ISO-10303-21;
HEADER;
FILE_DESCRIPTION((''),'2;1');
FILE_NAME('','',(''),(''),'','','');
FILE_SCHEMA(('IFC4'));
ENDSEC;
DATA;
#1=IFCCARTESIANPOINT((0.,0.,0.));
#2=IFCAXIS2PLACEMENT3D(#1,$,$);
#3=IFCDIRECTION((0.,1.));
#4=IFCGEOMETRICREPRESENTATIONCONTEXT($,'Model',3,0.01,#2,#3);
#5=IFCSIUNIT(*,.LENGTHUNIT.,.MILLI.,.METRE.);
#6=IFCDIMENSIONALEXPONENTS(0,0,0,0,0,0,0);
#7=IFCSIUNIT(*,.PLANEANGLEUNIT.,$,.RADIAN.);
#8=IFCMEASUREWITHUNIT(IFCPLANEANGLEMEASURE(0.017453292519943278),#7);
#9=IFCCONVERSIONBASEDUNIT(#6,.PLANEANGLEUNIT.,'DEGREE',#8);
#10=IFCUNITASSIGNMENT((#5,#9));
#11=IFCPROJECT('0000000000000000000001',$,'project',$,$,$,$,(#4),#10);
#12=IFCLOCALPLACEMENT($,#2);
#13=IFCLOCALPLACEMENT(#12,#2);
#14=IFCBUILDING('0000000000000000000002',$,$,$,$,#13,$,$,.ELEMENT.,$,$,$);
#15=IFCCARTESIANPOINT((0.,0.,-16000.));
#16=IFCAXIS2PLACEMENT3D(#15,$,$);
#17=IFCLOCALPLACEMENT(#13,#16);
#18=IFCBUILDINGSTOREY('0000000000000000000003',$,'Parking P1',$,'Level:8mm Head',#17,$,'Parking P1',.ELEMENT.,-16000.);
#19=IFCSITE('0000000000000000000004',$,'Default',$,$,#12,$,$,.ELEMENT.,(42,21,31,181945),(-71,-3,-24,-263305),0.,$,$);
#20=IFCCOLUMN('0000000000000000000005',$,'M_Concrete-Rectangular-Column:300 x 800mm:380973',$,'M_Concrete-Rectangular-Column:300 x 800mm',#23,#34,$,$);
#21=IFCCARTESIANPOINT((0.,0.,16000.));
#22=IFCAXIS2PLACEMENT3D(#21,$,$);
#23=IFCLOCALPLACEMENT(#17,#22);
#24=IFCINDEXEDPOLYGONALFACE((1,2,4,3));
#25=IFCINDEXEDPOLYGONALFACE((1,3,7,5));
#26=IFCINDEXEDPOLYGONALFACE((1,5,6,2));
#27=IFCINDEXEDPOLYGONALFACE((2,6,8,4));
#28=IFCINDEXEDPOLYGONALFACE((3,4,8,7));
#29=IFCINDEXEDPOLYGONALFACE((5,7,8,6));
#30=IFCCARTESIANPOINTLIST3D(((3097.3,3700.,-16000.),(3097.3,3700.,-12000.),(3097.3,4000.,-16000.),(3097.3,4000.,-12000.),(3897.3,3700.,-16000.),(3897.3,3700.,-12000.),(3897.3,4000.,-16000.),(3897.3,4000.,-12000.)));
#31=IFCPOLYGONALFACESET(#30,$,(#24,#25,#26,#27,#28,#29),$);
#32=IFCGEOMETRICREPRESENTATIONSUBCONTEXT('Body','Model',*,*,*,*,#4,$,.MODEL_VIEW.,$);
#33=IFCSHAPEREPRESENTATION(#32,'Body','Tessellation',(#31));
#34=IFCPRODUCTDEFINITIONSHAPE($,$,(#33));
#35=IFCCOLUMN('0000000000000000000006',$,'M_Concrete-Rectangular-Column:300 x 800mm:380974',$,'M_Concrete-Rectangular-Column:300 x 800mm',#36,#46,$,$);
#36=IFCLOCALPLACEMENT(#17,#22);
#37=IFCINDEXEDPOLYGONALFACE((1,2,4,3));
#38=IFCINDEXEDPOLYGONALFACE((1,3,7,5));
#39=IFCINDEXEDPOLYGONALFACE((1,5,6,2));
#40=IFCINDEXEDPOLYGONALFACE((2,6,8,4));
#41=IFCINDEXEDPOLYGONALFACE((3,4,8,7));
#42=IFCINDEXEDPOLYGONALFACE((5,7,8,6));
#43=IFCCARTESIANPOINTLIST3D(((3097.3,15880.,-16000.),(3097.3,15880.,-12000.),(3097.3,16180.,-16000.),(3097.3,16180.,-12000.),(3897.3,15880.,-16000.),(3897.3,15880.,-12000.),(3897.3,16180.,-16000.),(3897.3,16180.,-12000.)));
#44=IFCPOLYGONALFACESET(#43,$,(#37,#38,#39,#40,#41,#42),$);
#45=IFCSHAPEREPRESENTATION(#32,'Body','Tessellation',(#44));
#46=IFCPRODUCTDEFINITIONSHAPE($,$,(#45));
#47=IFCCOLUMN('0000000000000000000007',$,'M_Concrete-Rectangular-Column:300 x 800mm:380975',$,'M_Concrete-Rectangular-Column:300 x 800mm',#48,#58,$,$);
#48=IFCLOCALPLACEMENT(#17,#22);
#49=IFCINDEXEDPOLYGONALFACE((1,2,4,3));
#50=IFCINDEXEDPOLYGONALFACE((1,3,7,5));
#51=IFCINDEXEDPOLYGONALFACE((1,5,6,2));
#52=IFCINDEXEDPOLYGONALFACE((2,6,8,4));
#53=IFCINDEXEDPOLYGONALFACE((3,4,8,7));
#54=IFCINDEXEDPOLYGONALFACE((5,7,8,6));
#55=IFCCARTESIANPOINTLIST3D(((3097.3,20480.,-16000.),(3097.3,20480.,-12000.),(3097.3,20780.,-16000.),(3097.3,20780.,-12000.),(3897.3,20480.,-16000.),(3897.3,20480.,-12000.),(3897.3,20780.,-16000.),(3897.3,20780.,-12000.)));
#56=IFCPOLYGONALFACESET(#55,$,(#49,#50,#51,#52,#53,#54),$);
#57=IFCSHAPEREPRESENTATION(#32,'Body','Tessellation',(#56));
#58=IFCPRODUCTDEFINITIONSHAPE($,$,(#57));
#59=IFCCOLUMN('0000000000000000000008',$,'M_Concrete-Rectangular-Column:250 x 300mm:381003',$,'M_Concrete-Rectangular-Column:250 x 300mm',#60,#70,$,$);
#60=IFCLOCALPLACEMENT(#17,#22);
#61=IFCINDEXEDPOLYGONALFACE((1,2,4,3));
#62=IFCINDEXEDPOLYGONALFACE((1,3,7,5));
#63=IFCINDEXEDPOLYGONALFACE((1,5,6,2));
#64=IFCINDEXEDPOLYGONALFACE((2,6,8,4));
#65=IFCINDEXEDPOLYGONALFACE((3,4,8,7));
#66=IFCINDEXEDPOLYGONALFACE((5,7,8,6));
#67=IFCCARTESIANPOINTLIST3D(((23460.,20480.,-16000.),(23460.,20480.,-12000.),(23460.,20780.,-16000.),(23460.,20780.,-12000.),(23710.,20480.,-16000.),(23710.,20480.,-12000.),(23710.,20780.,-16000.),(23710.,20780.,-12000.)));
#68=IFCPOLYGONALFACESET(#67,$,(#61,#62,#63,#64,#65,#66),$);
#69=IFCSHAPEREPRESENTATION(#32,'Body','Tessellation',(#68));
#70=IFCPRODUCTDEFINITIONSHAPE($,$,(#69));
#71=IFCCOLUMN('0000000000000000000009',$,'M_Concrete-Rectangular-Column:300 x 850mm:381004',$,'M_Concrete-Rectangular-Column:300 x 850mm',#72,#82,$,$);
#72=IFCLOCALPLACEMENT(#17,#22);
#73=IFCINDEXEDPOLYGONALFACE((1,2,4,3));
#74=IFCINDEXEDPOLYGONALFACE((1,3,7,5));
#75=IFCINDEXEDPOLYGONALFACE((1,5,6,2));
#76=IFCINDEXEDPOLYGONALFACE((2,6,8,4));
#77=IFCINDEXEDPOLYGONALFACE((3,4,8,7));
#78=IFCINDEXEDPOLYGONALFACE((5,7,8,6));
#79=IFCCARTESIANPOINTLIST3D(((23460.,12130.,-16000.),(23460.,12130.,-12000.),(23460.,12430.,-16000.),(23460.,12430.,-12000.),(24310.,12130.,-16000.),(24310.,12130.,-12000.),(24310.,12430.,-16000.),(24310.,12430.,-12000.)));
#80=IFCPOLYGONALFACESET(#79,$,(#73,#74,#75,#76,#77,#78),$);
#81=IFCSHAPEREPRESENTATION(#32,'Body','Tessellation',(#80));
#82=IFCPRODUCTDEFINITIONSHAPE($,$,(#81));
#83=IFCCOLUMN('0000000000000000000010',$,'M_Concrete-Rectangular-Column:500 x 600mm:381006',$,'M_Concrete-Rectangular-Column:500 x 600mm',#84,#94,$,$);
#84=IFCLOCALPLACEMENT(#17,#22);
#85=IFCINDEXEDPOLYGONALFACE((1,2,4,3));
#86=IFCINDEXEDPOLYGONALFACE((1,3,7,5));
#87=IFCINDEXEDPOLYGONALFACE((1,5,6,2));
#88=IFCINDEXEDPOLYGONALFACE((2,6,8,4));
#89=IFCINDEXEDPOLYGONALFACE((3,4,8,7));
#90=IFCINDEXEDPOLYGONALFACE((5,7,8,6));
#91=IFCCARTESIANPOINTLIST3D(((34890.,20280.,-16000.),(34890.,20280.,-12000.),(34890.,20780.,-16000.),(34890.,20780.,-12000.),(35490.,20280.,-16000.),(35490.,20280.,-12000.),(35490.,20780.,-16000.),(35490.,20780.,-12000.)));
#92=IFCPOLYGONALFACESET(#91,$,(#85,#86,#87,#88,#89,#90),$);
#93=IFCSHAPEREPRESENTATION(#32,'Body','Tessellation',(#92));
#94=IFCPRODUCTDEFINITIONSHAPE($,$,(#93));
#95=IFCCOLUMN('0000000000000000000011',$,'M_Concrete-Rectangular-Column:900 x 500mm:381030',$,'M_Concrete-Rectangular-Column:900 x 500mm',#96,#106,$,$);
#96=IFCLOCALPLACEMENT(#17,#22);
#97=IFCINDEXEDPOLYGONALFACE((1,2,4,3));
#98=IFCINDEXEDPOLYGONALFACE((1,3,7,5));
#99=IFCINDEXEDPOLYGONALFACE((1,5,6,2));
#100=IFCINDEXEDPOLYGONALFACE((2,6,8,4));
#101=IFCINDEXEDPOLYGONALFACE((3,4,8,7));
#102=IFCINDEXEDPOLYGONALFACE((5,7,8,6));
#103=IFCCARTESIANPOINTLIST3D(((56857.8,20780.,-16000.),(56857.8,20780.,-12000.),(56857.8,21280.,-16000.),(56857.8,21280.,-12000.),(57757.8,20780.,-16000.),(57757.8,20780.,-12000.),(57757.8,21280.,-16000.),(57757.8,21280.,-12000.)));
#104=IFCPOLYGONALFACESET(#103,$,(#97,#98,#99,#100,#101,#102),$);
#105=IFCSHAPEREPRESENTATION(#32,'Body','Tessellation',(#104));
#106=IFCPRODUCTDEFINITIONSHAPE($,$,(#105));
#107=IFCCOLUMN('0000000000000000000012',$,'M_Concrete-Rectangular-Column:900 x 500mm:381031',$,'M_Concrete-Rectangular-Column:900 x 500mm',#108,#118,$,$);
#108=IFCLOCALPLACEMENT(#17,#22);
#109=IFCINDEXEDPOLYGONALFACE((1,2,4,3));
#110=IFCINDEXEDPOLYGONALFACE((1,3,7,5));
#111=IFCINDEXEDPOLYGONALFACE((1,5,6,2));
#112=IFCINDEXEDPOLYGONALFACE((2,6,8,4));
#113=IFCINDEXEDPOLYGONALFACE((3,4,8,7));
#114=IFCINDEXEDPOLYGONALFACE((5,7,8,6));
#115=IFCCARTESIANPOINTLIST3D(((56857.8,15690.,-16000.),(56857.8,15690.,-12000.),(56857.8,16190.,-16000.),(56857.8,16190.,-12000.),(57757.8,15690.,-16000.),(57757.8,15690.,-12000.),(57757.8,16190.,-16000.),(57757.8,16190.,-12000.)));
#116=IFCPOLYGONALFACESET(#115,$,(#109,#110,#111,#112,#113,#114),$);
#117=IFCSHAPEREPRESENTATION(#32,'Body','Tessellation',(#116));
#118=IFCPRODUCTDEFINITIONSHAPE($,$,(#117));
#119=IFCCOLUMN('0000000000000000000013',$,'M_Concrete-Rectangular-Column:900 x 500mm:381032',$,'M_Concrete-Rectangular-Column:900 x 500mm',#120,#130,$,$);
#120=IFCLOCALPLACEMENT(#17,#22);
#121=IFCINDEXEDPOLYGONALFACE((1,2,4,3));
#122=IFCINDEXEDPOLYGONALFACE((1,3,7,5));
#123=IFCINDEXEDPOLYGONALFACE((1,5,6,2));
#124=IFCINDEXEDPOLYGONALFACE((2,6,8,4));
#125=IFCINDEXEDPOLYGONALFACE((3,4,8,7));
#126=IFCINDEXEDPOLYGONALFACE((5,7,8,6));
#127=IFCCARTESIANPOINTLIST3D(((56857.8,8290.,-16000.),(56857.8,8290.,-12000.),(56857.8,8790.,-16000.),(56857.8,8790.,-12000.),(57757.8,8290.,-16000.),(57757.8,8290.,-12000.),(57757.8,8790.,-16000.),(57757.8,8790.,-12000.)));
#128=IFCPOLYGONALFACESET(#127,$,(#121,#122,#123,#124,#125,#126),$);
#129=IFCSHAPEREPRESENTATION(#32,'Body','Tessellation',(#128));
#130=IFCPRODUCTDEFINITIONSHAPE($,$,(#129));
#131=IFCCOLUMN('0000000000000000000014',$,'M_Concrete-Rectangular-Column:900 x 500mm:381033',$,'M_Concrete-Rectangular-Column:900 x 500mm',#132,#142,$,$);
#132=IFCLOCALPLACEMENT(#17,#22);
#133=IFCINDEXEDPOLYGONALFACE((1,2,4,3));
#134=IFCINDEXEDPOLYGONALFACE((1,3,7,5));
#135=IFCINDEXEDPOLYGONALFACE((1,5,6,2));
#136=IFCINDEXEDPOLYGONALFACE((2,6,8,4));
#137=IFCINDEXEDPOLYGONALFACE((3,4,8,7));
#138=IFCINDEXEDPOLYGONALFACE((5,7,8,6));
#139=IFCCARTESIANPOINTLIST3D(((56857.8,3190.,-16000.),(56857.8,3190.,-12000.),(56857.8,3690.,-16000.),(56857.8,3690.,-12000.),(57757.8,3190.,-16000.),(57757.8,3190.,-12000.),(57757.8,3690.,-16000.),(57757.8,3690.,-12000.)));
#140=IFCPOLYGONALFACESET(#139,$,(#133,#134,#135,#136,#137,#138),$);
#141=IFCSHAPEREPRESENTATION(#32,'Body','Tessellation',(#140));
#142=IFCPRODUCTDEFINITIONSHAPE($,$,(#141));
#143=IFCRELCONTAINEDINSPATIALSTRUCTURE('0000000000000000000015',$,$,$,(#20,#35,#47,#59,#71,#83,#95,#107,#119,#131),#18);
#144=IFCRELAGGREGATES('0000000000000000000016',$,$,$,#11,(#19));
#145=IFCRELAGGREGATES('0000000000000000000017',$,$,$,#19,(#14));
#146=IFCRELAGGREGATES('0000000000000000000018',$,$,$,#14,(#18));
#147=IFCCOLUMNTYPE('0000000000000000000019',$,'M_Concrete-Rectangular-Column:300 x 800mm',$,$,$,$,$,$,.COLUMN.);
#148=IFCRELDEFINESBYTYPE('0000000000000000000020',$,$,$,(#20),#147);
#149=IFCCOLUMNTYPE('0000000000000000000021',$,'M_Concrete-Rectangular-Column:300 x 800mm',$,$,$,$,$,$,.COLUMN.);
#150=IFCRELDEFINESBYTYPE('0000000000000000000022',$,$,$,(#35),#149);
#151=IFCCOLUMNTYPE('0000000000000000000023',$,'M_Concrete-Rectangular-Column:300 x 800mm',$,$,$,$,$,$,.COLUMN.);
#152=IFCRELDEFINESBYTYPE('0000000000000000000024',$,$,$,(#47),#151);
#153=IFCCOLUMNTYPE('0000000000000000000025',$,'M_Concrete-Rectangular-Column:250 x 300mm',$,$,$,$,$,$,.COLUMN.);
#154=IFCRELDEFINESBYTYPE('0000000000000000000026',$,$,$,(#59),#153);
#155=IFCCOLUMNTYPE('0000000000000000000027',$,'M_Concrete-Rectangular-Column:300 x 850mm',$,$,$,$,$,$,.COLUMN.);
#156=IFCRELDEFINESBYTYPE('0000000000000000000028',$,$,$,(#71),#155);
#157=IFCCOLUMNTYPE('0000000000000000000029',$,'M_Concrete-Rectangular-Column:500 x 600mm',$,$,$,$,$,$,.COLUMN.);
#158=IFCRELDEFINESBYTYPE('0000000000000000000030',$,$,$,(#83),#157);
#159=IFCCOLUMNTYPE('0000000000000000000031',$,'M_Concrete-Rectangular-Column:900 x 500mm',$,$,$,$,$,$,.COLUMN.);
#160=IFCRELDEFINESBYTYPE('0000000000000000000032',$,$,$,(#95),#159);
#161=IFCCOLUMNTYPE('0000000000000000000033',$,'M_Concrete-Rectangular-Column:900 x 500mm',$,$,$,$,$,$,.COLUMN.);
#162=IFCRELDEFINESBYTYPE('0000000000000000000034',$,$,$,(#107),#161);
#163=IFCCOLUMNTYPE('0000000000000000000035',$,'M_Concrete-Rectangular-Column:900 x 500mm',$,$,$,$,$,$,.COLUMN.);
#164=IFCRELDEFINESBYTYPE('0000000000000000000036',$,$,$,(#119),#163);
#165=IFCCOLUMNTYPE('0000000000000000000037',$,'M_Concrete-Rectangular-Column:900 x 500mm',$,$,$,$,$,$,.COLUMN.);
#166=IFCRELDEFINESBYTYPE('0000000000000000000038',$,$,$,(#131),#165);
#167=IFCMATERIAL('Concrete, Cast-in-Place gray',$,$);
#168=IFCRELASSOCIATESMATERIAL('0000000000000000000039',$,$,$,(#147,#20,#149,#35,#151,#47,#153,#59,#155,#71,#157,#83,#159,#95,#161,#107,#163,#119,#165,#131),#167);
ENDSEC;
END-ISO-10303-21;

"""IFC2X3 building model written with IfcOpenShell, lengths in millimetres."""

from ifc_helpers import new_model, entity, si_unit, converted_unit, direction, frame, frame_2d, origin, origin_2d_with_axis, place, context, subcontext, project, spatial, rectangle, extrude, source, transform, mapped, material, type_object, type_shapes, element, save


model = new_model("IFC2X3")

# Units and contexts
model_context = context("Model", 3, precision=0.01, world=origin(), true_north=direction((0.0, 1.0)))
body_context = subcontext(model_context, "Body", "Model", "MODEL_VIEW")
ifc_project = project(units=[si_unit("LENGTHUNIT", "METRE", prefix="MILLI"), converted_unit("PLANEANGLEUNIT", "DEGREE", entity("IfcPlaneAngleMeasure", 0.017453292519943278), si_unit("PLANEANGLEUNIT", "RADIAN"), dimensions=[0, 0, 0, 0, 0, 0, 0])], contexts=[model_context])

# Site, building, storey
site_placement = place(None, origin())
site = spatial("IfcSite", under=ifc_project, at=site_placement, Name="Default", CompositionType="ELEMENT", RefLatitude=(42, 21, 31, 181945), RefLongitude=(-71, -3, -24, -263305), RefElevation=0.0)
building_placement = place(site_placement, origin())
building = spatial("IfcBuilding", under=site, at=building_placement, CompositionType="ELEMENT")
storey_placement = place(building_placement, frame((0.0, 0.0, -16000.0)))
storey = spatial("IfcBuildingStorey", under=building, at=storey_placement, Name="Parking P1", ObjectType="Level:8mm Head", LongName="Parking P1", CompositionType="ELEMENT", Elevation=-16000.0)

# Columns
ifc_material_1 = material(Name="Concrete, Cast-in-Place gray")
column_type_1 = type_object("IfcColumnType", Name="M_Concrete-Rectangular-Column:300 x 800mm", PredefinedType="COLUMN", material=ifc_material_1)
shared_shape_1 = source(origin(), body_context, "Body", "SweptSolid", [
    extrude(rectangle(XDim=300.0, YDim=800.0, at=frame_2d((0.0, 0.0), x_axis=(1.0, 0.0))), frame((3497.3, 3850.0, -16000.0), z_axis=(0.0, 0.0, 1.0), x_axis=(0.0, 1.0, 0.0)), (0.0, 0.0, 1.0), 4000.0),
])
type_shapes(column_type_1, [shared_shape_1])
column_1_placement = place(storey_placement, frame((0.0, 0.0, 16000.0)))
element("IfcColumn", 1, at=column_1_placement, inside=storey, type_object=column_type_1, material=ifc_material_1, Name="M_Concrete-Rectangular-Column:300 x 800mm:380973", ObjectType="M_Concrete-Rectangular-Column:300 x 800mm", context=body_context, shape_type="MappedRepresentation", body=[
    mapped(shared_shape_1, transform((0.0, 0.0, 0.0), scale=1.0)),
])
column_type_2 = type_object("IfcColumnType", Name="M_Concrete-Rectangular-Column:300 x 800mm", PredefinedType="COLUMN", material=ifc_material_1)
shared_shape_2 = source(origin(), body_context, "Body", "SweptSolid", [
    extrude(rectangle(XDim=300.0, YDim=800.0, at=frame_2d((0.0, 0.0), x_axis=(1.0, 0.0))), frame((3497.3, 16030.0, -16000.0), z_axis=(0.0, 0.0, 1.0), x_axis=(0.0, 1.0, 0.0)), (0.0, 0.0, 1.0), 4000.0),
])
type_shapes(column_type_2, [shared_shape_2])
column_2_placement = place(storey_placement, frame((0.0, 0.0, 16000.0)))
element("IfcColumn", 2, at=column_2_placement, inside=storey, type_object=column_type_2, material=ifc_material_1, Name="M_Concrete-Rectangular-Column:300 x 800mm:380974", ObjectType="M_Concrete-Rectangular-Column:300 x 800mm", context=body_context, shape_type="MappedRepresentation", body=[
    mapped(shared_shape_2, transform((0.0, 0.0, 0.0), scale=1.0)),
])
column_type_3 = type_object("IfcColumnType", Name="M_Concrete-Rectangular-Column:300 x 800mm", PredefinedType="COLUMN", material=ifc_material_1)
shared_shape_3 = source(origin(), body_context, "Body", "SweptSolid", [
    extrude(rectangle(XDim=300.0, YDim=800.0, at=frame_2d((0.0, 0.0), x_axis=(1.0, 0.0))), frame((3497.3, 20630.0, -16000.0), z_axis=(0.0, 0.0, 1.0), x_axis=(0.0, 1.0, 0.0)), (0.0, 0.0, 1.0), 4000.0),
])
type_shapes(column_type_3, [shared_shape_3])
column_3_placement = place(storey_placement, frame((0.0, 0.0, 16000.0)))
element("IfcColumn", 3, at=column_3_placement, inside=storey, type_object=column_type_3, material=ifc_material_1, Name="M_Concrete-Rectangular-Column:300 x 800mm:380975", ObjectType="M_Concrete-Rectangular-Column:300 x 800mm", context=body_context, shape_type="MappedRepresentation", body=[
    mapped(shared_shape_3, transform((0.0, 0.0, 0.0), scale=1.0)),
])
column_type_4 = type_object("IfcColumnType", Name="M_Concrete-Rectangular-Column:250 x 300mm", PredefinedType="COLUMN", material=ifc_material_1)
shared_shape_4 = source(origin(), body_context, "Body", "SweptSolid", [
    extrude(rectangle(XDim=250.0, YDim=300.0, at=frame_2d((0.0, 0.0), x_axis=(1.0, 0.0))), frame((23585.0, 20630.0, -16000.0), z_axis=(0.0, 0.0, 1.0), x_axis=(-1.0, 0.0, 0.0)), (0.0, 0.0, 1.0), 4000.0),
])
type_shapes(column_type_4, [shared_shape_4])
column_4_placement = place(storey_placement, frame((0.0, 0.0, 16000.0)))
element("IfcColumn", 4, at=column_4_placement, inside=storey, type_object=column_type_4, material=ifc_material_1, Name="M_Concrete-Rectangular-Column:250 x 300mm:381003", ObjectType="M_Concrete-Rectangular-Column:250 x 300mm", context=body_context, shape_type="MappedRepresentation", body=[
    mapped(shared_shape_4, transform((0.0, 0.0, 0.0), scale=1.0)),
])
column_type_5 = type_object("IfcColumnType", Name="M_Concrete-Rectangular-Column:300 x 850mm", PredefinedType="COLUMN", material=ifc_material_1)
shared_shape_5 = source(origin(), body_context, "Body", "SweptSolid", [
    extrude(rectangle(XDim=300.0, YDim=850.0, at=frame_2d((0.0, 0.0), x_axis=(1.0, 0.0))), frame((23885.0, 12280.0, -16000.0), z_axis=(0.0, 0.0, 1.0), x_axis=(0.0, -1.0, 0.0)), (0.0, 0.0, 1.0), 4000.0),
])
type_shapes(column_type_5, [shared_shape_5])
column_5_placement = place(storey_placement, frame((0.0, 0.0, 16000.0)))
element("IfcColumn", 5, at=column_5_placement, inside=storey, type_object=column_type_5, material=ifc_material_1, Name="M_Concrete-Rectangular-Column:300 x 850mm:381004", ObjectType="M_Concrete-Rectangular-Column:300 x 850mm", context=body_context, shape_type="MappedRepresentation", body=[
    mapped(shared_shape_5, transform((0.0, 0.0, 0.0), scale=1.0)),
])
column_type_6 = type_object("IfcColumnType", Name="M_Concrete-Rectangular-Column:500 x 600mm", PredefinedType="COLUMN", material=ifc_material_1)
shared_shape_6 = source(origin(), body_context, "Body", "SweptSolid", [
    extrude(rectangle(XDim=500.0, YDim=600.0, at=frame_2d((0.0, 0.0), x_axis=(1.0, 0.0))), frame((35190.0, 20530.0, -16000.0), z_axis=(0.0, 0.0, 1.0), x_axis=(0.0, -1.0, 0.0)), (0.0, 0.0, 1.0), 4000.0),
])
type_shapes(column_type_6, [shared_shape_6])
column_6_placement = place(storey_placement, frame((0.0, 0.0, 16000.0)))
element("IfcColumn", 6, at=column_6_placement, inside=storey, type_object=column_type_6, material=ifc_material_1, Name="M_Concrete-Rectangular-Column:500 x 600mm:381006", ObjectType="M_Concrete-Rectangular-Column:500 x 600mm", context=body_context, shape_type="MappedRepresentation", body=[
    mapped(shared_shape_6, transform((0.0, 0.0, 0.0), scale=1.0)),
])
column_type_7 = type_object("IfcColumnType", Name="M_Concrete-Rectangular-Column:900 x 500mm", PredefinedType="COLUMN", material=ifc_material_1)
shared_shape_7 = source(origin(), body_context, "Body", "SweptSolid", [
    extrude(rectangle(XDim=900.0, YDim=500.0, at=origin_2d_with_axis()), frame((57307.8, 21030.0, -16000.0), z_axis=(0.0, 0.0, 1.0), x_axis=(-1.0, 0.0, 0.0)), (0.0, 0.0, 1.0), 4000.0),
])
type_shapes(column_type_7, [shared_shape_7])
column_7_placement = place(storey_placement, frame((0.0, 0.0, 16000.0)))
element("IfcColumn", 7, at=column_7_placement, inside=storey, type_object=column_type_7, material=ifc_material_1, Name="M_Concrete-Rectangular-Column:900 x 500mm:381030", ObjectType="M_Concrete-Rectangular-Column:900 x 500mm", context=body_context, shape_type="MappedRepresentation", body=[
    mapped(shared_shape_7, transform((0.0, 0.0, 0.0), scale=1.0)),
])
column_type_8 = type_object("IfcColumnType", Name="M_Concrete-Rectangular-Column:900 x 500mm", PredefinedType="COLUMN", material=ifc_material_1)
shared_shape_8 = source(origin(), body_context, "Body", "SweptSolid", [
    extrude(rectangle(XDim=900.0, YDim=500.0, at=origin_2d_with_axis()), frame((57307.8, 15940.0, -16000.0), z_axis=(0.0, 0.0, 1.0), x_axis=(-1.0, 0.0, 0.0)), (0.0, 0.0, 1.0), 4000.0),
])
type_shapes(column_type_8, [shared_shape_8])
column_8_placement = place(storey_placement, frame((0.0, 0.0, 16000.0)))
element("IfcColumn", 8, at=column_8_placement, inside=storey, type_object=column_type_8, material=ifc_material_1, Name="M_Concrete-Rectangular-Column:900 x 500mm:381031", ObjectType="M_Concrete-Rectangular-Column:900 x 500mm", context=body_context, shape_type="MappedRepresentation", body=[
    mapped(shared_shape_8, transform((0.0, 0.0, 0.0), scale=1.0)),
])
column_type_9 = type_object("IfcColumnType", Name="M_Concrete-Rectangular-Column:900 x 500mm", PredefinedType="COLUMN", material=ifc_material_1)
shared_shape_9 = source(origin(), body_context, "Body", "SweptSolid", [
    extrude(rectangle(XDim=900.0, YDim=500.0, at=frame_2d((0.0, 0.0), x_axis=(1.0, 0.0))), frame((57307.8, 8540.0, -16000.0), z_axis=(0.0, 0.0, 1.0), x_axis=(-1.0, 0.0, 0.0)), (0.0, 0.0, 1.0), 4000.0),
])
type_shapes(column_type_9, [shared_shape_9])
column_9_placement = place(storey_placement, frame((0.0, 0.0, 16000.0)))
element("IfcColumn", 9, at=column_9_placement, inside=storey, type_object=column_type_9, material=ifc_material_1, Name="M_Concrete-Rectangular-Column:900 x 500mm:381032", ObjectType="M_Concrete-Rectangular-Column:900 x 500mm", context=body_context, shape_type="MappedRepresentation", body=[
    mapped(shared_shape_9, transform((0.0, 0.0, 0.0), scale=1.0)),
])
column_type_10 = type_object("IfcColumnType", Name="M_Concrete-Rectangular-Column:900 x 500mm", PredefinedType="COLUMN", material=ifc_material_1)
shared_shape_10 = source(origin(), body_context, "Body", "SweptSolid", [
    extrude(rectangle(XDim=900.0, YDim=500.0, at=origin_2d_with_axis()), frame((57307.8, 3440.0, -16000.0), z_axis=(0.0, 0.0, 1.0), x_axis=(-1.0, 0.0, 0.0)), (0.0, 0.0, 1.0), 4000.0),
])
type_shapes(column_type_10, [shared_shape_10])
column_10_placement = place(storey_placement, frame((0.0, 0.0, 16000.0)))
element("IfcColumn", 10, at=column_10_placement, inside=storey, type_object=column_type_10, material=ifc_material_1, Name="M_Concrete-Rectangular-Column:900 x 500mm:381033", ObjectType="M_Concrete-Rectangular-Column:900 x 500mm", context=body_context, shape_type="MappedRepresentation", body=[
    mapped(shared_shape_10, transform((0.0, 0.0, 0.0), scale=1.0)),
])

save(model, "model.ifc")
